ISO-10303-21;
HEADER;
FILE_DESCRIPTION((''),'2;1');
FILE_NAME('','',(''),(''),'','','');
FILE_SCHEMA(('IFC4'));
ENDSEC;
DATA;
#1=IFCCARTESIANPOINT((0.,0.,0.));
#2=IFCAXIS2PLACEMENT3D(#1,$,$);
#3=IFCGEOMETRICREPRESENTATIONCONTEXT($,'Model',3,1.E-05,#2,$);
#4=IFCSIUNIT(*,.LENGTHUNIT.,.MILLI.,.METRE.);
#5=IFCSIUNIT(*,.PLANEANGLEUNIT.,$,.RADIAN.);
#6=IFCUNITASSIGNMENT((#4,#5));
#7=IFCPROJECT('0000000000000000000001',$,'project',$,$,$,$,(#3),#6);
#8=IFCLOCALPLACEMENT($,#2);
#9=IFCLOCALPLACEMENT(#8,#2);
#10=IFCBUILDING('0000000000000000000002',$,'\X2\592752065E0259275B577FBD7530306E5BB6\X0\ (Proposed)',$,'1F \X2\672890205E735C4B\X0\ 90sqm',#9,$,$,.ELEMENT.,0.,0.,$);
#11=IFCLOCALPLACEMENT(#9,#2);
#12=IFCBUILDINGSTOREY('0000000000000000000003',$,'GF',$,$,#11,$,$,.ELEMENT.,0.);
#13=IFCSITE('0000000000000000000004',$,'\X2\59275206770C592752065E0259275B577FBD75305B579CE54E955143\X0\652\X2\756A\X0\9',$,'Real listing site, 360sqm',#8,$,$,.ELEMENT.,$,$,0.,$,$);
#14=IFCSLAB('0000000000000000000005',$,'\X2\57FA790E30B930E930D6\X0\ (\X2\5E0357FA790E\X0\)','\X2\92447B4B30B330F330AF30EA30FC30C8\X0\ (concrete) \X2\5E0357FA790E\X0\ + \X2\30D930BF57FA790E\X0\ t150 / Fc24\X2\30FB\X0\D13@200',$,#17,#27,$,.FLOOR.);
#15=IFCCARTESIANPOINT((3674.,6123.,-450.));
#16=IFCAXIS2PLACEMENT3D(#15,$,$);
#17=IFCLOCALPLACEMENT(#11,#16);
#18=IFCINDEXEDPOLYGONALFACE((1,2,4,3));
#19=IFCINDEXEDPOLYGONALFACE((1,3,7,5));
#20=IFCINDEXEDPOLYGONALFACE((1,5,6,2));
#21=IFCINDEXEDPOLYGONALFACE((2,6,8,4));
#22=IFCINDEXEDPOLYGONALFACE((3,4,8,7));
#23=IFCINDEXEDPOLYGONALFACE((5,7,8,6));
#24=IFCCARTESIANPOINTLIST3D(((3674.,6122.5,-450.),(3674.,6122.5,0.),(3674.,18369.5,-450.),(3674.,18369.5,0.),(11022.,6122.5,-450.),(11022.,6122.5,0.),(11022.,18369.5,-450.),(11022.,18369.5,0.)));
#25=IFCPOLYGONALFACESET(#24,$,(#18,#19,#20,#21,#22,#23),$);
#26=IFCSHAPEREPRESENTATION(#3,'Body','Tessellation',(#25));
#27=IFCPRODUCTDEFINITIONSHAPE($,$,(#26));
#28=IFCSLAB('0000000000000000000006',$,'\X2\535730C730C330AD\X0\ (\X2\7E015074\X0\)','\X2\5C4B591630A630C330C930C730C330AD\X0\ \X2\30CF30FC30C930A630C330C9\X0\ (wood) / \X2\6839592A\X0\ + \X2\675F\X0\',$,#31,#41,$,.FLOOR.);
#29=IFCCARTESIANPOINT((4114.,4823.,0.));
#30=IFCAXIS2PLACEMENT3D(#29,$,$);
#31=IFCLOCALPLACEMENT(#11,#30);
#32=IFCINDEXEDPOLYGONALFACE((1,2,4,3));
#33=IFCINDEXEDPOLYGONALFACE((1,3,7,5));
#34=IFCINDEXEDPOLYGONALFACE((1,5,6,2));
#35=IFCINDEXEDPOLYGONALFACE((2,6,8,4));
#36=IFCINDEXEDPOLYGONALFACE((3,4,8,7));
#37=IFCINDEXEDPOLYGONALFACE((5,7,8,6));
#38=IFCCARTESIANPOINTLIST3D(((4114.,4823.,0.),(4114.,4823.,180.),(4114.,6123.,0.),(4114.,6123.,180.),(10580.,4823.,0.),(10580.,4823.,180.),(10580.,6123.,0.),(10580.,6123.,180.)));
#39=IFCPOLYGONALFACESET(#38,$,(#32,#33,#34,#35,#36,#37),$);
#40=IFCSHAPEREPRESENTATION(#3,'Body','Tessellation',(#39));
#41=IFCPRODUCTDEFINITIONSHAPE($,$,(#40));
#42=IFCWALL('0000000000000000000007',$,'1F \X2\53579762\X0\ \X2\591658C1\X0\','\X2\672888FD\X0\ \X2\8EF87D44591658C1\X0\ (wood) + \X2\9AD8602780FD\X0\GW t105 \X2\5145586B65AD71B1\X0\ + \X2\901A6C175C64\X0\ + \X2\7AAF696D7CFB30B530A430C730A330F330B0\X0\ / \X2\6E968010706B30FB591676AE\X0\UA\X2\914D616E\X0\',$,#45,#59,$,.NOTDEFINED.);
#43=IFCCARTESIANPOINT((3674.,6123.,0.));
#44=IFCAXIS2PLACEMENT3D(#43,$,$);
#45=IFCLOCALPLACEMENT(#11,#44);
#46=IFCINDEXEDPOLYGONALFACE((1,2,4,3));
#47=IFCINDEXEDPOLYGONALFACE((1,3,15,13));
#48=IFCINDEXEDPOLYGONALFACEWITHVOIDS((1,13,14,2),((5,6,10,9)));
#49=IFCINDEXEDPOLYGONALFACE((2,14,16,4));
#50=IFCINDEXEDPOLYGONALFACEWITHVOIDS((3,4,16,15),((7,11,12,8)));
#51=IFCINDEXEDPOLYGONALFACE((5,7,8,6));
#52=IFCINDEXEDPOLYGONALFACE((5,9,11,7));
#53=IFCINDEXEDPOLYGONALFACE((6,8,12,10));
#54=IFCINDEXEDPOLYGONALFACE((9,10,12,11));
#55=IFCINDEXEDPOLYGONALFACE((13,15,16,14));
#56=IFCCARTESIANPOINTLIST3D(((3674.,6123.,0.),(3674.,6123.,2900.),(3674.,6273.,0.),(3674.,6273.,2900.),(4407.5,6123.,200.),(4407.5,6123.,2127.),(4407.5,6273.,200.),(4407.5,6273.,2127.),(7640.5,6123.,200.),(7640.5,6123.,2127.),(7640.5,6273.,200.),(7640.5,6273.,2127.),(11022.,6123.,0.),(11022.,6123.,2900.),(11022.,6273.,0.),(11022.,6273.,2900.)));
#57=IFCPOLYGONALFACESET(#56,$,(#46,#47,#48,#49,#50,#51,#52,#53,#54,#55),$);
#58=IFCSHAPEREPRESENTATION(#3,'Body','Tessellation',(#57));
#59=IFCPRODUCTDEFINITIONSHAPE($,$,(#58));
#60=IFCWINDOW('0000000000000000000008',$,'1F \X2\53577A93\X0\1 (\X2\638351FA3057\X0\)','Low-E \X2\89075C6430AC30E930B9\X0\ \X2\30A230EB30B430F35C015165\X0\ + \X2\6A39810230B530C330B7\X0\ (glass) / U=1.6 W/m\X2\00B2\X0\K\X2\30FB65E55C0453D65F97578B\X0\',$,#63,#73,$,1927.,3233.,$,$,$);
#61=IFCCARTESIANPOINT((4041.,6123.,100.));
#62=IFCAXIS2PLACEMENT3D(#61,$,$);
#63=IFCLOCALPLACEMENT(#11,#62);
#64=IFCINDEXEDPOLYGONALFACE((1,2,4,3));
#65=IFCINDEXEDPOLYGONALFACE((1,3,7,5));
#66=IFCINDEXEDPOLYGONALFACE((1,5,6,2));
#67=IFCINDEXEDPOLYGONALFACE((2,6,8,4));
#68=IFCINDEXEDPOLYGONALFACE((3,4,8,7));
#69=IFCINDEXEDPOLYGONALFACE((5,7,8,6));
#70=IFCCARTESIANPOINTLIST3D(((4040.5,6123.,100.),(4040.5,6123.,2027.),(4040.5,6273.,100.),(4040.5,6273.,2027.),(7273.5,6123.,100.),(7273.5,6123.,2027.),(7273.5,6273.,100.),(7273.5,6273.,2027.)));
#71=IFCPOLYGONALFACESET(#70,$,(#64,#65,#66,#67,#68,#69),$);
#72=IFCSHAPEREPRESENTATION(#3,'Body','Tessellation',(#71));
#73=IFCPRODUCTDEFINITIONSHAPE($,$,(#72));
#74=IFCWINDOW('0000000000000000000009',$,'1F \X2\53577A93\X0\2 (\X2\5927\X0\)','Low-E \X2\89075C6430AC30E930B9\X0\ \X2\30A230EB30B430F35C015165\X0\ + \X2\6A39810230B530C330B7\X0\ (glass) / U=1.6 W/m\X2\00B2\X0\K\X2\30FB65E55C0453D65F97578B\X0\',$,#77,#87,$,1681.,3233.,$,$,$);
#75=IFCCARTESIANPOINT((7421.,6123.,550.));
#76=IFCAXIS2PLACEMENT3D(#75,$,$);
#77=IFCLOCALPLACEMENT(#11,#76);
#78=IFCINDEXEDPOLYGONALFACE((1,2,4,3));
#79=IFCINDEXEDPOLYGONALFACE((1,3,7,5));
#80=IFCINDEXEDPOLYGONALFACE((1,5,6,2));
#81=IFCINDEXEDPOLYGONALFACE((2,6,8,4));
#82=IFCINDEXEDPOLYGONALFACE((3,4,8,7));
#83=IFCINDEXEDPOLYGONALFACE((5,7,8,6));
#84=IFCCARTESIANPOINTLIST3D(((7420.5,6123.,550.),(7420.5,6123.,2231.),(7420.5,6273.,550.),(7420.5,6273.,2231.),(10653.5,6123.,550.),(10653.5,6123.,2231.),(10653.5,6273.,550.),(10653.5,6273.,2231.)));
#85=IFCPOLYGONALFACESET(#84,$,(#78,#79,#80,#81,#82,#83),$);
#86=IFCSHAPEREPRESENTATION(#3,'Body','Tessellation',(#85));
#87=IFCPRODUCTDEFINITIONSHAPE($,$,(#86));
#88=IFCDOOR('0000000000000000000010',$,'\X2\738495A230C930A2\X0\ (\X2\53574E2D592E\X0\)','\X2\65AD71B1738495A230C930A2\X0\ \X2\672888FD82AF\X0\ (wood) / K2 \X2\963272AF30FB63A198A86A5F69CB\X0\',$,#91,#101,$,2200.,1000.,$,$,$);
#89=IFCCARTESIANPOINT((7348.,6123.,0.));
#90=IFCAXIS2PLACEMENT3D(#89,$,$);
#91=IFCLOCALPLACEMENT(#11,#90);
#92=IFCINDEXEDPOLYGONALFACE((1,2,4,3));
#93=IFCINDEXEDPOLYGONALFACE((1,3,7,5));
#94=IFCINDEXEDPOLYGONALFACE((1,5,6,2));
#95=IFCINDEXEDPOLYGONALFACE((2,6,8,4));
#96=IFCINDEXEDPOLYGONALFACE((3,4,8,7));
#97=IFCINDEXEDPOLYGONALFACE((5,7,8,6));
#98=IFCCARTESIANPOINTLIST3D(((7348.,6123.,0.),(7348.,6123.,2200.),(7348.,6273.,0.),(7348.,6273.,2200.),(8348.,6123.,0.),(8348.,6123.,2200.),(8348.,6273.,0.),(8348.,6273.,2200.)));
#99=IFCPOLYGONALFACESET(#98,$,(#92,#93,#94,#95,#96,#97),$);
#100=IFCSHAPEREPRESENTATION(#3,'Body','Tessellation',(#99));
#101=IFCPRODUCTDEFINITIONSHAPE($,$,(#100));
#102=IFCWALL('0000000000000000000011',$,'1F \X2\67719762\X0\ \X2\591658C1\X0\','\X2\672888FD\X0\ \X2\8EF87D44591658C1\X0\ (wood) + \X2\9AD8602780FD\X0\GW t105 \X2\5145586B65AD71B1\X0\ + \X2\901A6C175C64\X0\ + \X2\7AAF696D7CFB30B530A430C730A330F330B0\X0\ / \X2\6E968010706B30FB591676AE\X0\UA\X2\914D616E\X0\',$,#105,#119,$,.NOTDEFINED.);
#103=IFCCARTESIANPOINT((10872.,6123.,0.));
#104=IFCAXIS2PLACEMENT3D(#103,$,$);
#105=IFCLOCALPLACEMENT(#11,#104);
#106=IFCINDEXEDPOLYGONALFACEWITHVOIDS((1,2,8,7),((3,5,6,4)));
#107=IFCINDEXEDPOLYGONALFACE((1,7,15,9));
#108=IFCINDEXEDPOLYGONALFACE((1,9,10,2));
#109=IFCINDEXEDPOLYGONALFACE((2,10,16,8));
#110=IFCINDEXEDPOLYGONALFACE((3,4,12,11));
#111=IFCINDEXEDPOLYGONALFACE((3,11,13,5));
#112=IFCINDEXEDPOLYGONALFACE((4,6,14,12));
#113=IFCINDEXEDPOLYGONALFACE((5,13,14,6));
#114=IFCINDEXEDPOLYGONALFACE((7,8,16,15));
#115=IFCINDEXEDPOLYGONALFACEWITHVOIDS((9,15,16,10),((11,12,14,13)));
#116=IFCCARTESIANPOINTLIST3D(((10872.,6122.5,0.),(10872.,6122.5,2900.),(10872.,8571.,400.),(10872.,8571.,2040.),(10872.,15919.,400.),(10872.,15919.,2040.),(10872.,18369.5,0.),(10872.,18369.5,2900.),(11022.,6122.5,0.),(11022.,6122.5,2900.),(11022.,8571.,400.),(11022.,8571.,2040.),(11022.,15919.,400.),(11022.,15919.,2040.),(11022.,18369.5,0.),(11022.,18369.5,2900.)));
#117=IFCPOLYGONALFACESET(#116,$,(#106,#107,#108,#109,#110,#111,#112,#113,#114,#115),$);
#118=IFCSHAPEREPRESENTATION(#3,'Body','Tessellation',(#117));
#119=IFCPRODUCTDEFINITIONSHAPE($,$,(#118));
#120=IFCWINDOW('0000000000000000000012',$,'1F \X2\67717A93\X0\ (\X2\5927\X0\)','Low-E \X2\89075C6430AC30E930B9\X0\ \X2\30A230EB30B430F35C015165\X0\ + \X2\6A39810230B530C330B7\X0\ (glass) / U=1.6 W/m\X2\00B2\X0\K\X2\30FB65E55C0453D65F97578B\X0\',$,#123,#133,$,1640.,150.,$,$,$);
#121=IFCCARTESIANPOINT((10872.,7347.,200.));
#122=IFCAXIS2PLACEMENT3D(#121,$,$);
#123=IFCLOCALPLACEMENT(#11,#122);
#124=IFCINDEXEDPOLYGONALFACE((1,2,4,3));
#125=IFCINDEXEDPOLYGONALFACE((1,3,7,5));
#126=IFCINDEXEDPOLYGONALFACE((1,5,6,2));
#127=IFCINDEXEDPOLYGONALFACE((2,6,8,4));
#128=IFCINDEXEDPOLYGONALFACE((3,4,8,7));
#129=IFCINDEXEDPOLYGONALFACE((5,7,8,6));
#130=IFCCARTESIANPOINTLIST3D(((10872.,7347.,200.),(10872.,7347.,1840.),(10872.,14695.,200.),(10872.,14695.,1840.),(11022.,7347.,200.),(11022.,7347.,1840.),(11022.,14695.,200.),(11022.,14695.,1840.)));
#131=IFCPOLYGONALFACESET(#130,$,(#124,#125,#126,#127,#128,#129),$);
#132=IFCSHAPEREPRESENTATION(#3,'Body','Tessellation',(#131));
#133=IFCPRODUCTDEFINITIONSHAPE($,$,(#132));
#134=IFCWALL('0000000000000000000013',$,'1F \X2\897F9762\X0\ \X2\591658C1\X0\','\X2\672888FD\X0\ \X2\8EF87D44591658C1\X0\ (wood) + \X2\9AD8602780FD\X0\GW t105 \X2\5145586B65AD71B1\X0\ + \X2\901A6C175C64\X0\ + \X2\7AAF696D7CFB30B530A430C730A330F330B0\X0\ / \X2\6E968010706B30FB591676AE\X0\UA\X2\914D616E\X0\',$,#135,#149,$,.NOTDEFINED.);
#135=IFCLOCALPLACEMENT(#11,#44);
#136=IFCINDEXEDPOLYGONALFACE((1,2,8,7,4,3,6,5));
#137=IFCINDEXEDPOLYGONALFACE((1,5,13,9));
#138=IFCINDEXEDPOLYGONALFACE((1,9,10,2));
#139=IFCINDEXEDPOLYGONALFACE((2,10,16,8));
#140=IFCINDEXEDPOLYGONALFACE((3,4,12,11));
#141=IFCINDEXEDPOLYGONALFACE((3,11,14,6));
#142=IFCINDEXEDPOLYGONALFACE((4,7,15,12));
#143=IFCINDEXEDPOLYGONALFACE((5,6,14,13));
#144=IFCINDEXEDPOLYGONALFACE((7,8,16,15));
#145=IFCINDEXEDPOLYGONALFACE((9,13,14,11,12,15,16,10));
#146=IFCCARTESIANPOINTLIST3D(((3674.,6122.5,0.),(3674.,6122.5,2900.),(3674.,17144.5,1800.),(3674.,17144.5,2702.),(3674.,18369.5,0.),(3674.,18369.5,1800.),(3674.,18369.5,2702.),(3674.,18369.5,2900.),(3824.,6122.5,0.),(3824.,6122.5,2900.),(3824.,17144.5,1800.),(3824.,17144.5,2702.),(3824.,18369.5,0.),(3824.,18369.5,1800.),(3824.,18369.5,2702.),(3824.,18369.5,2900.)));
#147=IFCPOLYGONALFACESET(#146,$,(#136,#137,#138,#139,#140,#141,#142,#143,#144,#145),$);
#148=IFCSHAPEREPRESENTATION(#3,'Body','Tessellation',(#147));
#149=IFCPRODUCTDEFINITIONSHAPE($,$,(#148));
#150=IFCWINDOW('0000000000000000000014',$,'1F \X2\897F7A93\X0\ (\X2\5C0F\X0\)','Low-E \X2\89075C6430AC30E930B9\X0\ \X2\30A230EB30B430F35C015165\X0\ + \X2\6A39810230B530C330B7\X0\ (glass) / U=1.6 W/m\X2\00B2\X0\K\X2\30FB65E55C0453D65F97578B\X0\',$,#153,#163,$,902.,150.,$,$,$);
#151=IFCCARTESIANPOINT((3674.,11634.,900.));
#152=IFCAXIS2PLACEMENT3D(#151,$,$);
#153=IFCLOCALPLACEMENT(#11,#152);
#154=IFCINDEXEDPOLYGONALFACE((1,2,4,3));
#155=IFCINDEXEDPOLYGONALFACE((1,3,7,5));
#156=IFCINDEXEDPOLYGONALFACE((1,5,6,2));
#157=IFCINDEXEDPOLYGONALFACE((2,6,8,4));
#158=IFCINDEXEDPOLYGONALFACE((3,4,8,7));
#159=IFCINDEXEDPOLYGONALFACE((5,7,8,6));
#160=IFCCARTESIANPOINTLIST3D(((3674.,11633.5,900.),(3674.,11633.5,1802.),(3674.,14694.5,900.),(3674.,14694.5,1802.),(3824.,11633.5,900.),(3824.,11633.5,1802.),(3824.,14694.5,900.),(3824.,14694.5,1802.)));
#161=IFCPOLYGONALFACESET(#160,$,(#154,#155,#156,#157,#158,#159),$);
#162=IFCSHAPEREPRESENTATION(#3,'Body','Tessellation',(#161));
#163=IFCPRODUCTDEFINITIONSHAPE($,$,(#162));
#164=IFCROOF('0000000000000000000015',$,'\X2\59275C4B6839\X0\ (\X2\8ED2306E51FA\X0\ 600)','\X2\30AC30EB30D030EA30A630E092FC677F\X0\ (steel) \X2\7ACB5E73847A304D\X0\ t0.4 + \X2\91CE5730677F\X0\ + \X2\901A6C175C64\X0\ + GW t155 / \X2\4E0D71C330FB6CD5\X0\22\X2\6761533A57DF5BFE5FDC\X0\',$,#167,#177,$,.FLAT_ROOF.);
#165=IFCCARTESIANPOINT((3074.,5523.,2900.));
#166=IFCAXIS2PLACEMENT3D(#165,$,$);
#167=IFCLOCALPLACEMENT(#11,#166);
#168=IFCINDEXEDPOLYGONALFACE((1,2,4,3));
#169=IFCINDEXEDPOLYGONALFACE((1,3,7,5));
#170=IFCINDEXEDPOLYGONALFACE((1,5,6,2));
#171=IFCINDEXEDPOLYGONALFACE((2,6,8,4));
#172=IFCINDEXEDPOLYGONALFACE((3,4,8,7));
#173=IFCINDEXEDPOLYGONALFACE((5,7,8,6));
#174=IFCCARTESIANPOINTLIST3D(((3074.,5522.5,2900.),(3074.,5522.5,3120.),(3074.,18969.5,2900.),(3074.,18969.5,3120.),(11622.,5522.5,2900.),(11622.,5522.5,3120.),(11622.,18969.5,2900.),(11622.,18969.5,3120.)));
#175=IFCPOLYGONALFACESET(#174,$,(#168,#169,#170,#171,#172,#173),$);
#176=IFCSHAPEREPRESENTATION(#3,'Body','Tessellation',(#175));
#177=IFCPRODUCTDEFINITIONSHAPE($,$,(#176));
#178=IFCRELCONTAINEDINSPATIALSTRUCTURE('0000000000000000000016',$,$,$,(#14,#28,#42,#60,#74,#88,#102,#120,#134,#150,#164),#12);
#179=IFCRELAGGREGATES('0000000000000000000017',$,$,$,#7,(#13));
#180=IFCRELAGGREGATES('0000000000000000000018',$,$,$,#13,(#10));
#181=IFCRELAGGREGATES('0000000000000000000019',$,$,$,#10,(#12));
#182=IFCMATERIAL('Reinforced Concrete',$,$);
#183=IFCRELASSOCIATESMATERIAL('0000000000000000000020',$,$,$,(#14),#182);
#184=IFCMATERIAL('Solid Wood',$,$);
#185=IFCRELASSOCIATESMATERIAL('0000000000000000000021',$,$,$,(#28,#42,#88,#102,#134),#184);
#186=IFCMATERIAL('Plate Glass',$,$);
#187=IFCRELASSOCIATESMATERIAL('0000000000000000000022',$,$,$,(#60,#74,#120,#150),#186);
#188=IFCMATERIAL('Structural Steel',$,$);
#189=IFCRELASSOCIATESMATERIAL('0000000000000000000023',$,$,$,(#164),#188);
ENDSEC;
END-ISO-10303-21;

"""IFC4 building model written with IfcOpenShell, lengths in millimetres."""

from ifc_helpers import new_model, si_unit, frame, frame_2d, origin, place, context, project, spatial, rectangle, extrude, material, element, fill, save


model = new_model("IFC4")

# Units and contexts
model_context = context("Model", 3, precision=1e-05, world=origin())
ifc_project = project(units=[si_unit("LENGTHUNIT", "METRE", prefix="MILLI"), si_unit("PLANEANGLEUNIT", "RADIAN")], contexts=[model_context])

# Site, building, storey
site_placement = place(None, origin())
site = spatial("IfcSite", under=ifc_project, at=site_placement, Name="大分県大分市大字羽田字鳥井元652番9", ObjectType="Real listing site, 360sqm", CompositionType="ELEMENT", RefElevation=0.0)
building_placement = place(site_placement, origin())
building = spatial("IfcBuilding", under=site, at=building_placement, Name="大分市大字羽田の家 (Proposed)", ObjectType="1F 木造平屋 90sqm", CompositionType="ELEMENT", ElevationOfRefHeight=0.0, ElevationOfTerrain=0.0)
storey_placement = place(building_placement, origin())
storey = spatial("IfcBuildingStorey", under=building, at=storey_placement, Name="GF", CompositionType="ELEMENT", Elevation=0.0)

# Slabs
ifc_material_1 = material(Name="Reinforced Concrete")
slab_1_placement = place(storey_placement, frame((3674.0, 6123.0, -450.0)))
element("IfcSlab", 1, at=slab_1_placement, inside=storey, material=ifc_material_1, Name="基礎スラブ (布基礎)", Description="鉄筋コンクリート (concrete) 布基礎 + ベタ基礎 t150 / Fc24・D13@200", PredefinedType="FLOOR", context=model_context, shape_type="SweptSolid", body=[
    extrude(rectangle(XDim=7348.0, YDim=12247.0, at=frame_2d((3674.0, 6123.0))), frame((3674.0, 6123.0, -450.0)), (0.0, 0.0, 1.0), 450.0),
])
ifc_material_2 = material(Name="Solid Wood")
slab_2_placement = place(storey_placement, frame((4114.0, 4823.0, 0.0)))
element("IfcSlab", 2, at=slab_2_placement, inside=storey, material=ifc_material_2, Name="南デッキ (縁側)", Description="屋外ウッドデッキ ハードウッド (wood) / 根太 + 束", PredefinedType="FLOOR", context=model_context, shape_type="SweptSolid", body=[
    extrude(rectangle(XDim=6466.0, YDim=1300.0, at=frame_2d((3233.0, 650.0))), frame((4114.0, 4823.0, 0.0)), (0.0, 0.0, 1.0), 180.0),
])

# Wall, openings, windows, door
wall_1_placement = place(storey_placement, frame((3674.0, 6123.0, 0.0)))
wall_1 = element("IfcWall", 3, at=wall_1_placement, inside=storey, material=ifc_material_2, Name="1F 南面 外壁", Description="木製 軸組外壁 (wood) + 高性能GW t105 充填断熱 + 通気層 + 窯業系サイディング / 準耐火・外皮UA配慮", PredefinedType="NOTDEFINED", context=model_context, shape_type="SweptSolid", body=[
    extrude(rectangle(XDim=7348.0, YDim=150.0, at=frame_2d((3674.0, 75.0))), frame((3674.0, 6123.0, 0.0)), (0.0, 0.0, 1.0), 2900.0),
])
opening_1_placement = place(storey_placement, frame((4041.0, 6123.0, 100.0)))
opening_1 = element("IfcOpeningElement", 4, at=opening_1_placement, cuts=wall_1, PredefinedType="NOTDEFINED", context=model_context, shape_type="SweptSolid", body=[
    extrude(rectangle(XDim=3233.0, YDim=150.0, at=frame_2d((1616.0, 75.0))), frame((4041.0, 6123.0, 100.0)), (0.0, 0.0, 1.0), 1927.0),
])
opening_2_placement = place(storey_placement, frame((7421.0, 6123.0, 550.0)))
opening_2 = element("IfcOpeningElement", 5, at=opening_2_placement, cuts=wall_1, PredefinedType="NOTDEFINED", context=model_context, shape_type="SweptSolid", body=[
    extrude(rectangle(XDim=3233.0, YDim=150.0, at=frame_2d((1616.0, 75.0))), frame((7421.0, 6123.0, 550.0)), (0.0, 0.0, 1.0), 1681.0),
])
opening_3_placement = place(storey_placement, frame((7348.0, 6123.0, 0.0)))
opening_3 = element("IfcOpeningElement", 6, at=opening_3_placement, cuts=wall_1, PredefinedType="NOTDEFINED", context=model_context, shape_type="SweptSolid", body=[
    extrude(rectangle(XDim=1000.0, YDim=150.0, at=frame_2d((500.0, 75.0))), frame((7348.0, 6123.0, 0.0)), (0.0, 0.0, 1.0), 2200.0),
])
ifc_material_3 = material(Name="Plate Glass")
window_1_placement = place(storey_placement, frame((4041.0, 6123.0, 100.0)))
window_1 = element("IfcWindow", 7, at=window_1_placement, inside=storey, material=ifc_material_3, Name="1F 南窓1 (掃出し)", Description="Low-E 複層ガラス アルゴン封入 + 樹脂サッシ (glass) / U=1.6 W/m²K・日射取得型", OverallHeight=1927.0, OverallWidth=3233.0, context=model_context, shape_type="SweptSolid", body=[
    extrude(rectangle(XDim=3233.0, YDim=150.0, at=frame_2d((1616.0, 75.0))), frame((4041.0, 6123.0, 100.0)), (0.0, 0.0, 1.0), 1927.0),
])
fill(opening_1, window_1)
window_2_placement = place(storey_placement, frame((7421.0, 6123.0, 550.0)))
window_2 = element("IfcWindow", 8, at=window_2_placement, inside=storey, material=ifc_material_3, Name="1F 南窓2 (大)", Description="Low-E 複層ガラス アルゴン封入 + 樹脂サッシ (glass) / U=1.6 W/m²K・日射取得型", OverallHeight=1681.0, OverallWidth=3233.0, context=model_context, shape_type="SweptSolid", body=[
    extrude(rectangle(XDim=3233.0, YDim=150.0, at=frame_2d((1616.0, 75.0))), frame((7421.0, 6123.0, 550.0)), (0.0, 0.0, 1.0), 1681.0),
])
fill(opening_2, window_2)
door_placement = place(storey_placement, frame((7348.0, 6123.0, 0.0)))
door = element("IfcDoor", 9, at=door_placement, inside=storey, material=ifc_material_2, Name="玄関ドア (南中央)", Description="断熱玄関ドア 木製芯 (wood) / K2 防犯・採風機構", OverallHeight=2200.0, OverallWidth=1000.0, context=model_context, shape_type="SweptSolid", body=[
    extrude(rectangle(XDim=1000.0, YDim=150.0, at=frame_2d((500.0, 75.0))), frame((7348.0, 6123.0, 0.0)), (0.0, 0.0, 1.0), 2200.0),
])
fill(opening_3, door)

# Walls, openings, windows
wall_2_placement = place(storey_placement, frame((10872.0, 6123.0, 0.0)))
wall_2 = element("IfcWall", 10, at=wall_2_placement, inside=storey, material=ifc_material_2, Name="1F 東面 外壁", Description="木製 軸組外壁 (wood) + 高性能GW t105 充填断熱 + 通気層 + 窯業系サイディング / 準耐火・外皮UA配慮", PredefinedType="NOTDEFINED", context=model_context, shape_type="SweptSolid", body=[
    extrude(rectangle(XDim=150.0, YDim=12247.0, at=frame_2d((75.0, 6123.0))), frame((10872.0, 6123.0, 0.0)), (0.0, 0.0, 1.0), 2900.0),
])
opening_4_placement = place(storey_placement, frame((10872.0, 7347.0, 200.0)))
opening_4 = element("IfcOpeningElement", 11, at=opening_4_placement, cuts=wall_2, PredefinedType="NOTDEFINED", context=model_context, shape_type="SweptSolid", body=[
    extrude(rectangle(XDim=150.0, YDim=7348.0, at=frame_2d((75.0, 3674.0))), frame((10872.0, 7347.0, 200.0)), (0.0, 0.0, 1.0), 1640.0),
])
window_3_placement = place(storey_placement, frame((10872.0, 7347.0, 200.0)))
window_3 = element("IfcWindow", 12, at=window_3_placement, inside=storey, material=ifc_material_3, Name="1F 東窓 (大)", Description="Low-E 複層ガラス アルゴン封入 + 樹脂サッシ (glass) / U=1.6 W/m²K・日射取得型", OverallHeight=1640.0, OverallWidth=150.0, context=model_context, shape_type="SweptSolid", body=[
    extrude(rectangle(XDim=150.0, YDim=7348.0, at=frame_2d((75.0, 3674.0))), frame((10872.0, 7347.0, 200.0)), (0.0, 0.0, 1.0), 1640.0),
])
fill(opening_4, window_3)
wall_3_placement = place(storey_placement, frame((3674.0, 6123.0, 0.0)))
wall_3 = element("IfcWall", 13, at=wall_3_placement, inside=storey, material=ifc_material_2, Name="1F 西面 外壁", Description="木製 軸組外壁 (wood) + 高性能GW t105 充填断熱 + 通気層 + 窯業系サイディング / 準耐火・外皮UA配慮", PredefinedType="NOTDEFINED", context=model_context, shape_type="SweptSolid", body=[
    extrude(rectangle(XDim=150.0, YDim=12247.0, at=frame_2d((75.0, 6123.0))), frame((3674.0, 6123.0, 0.0)), (0.0, 0.0, 1.0), 2900.0),
])
opening_5_placement = place(storey_placement, frame((3674.0, 11634.0, 900.0)))
opening_5 = element("IfcOpeningElement", 14, at=opening_5_placement, cuts=wall_3, PredefinedType="NOTDEFINED", context=model_context, shape_type="SweptSolid", body=[
    extrude(rectangle(XDim=150.0, YDim=3061.0, at=frame_2d((75.0, 1530.0))), frame((3674.0, 11634.0, 900.0)), (0.0, 0.0, 1.0), 902.0),
])
window_4_placement = place(storey_placement, frame((3674.0, 11634.0, 900.0)))
window_4 = element("IfcWindow", 15, at=window_4_placement, inside=storey, material=ifc_material_3, Name="1F 西窓 (小)", Description="Low-E 複層ガラス アルゴン封入 + 樹脂サッシ (glass) / U=1.6 W/m²K・日射取得型", OverallHeight=902.0, OverallWidth=150.0, context=model_context, shape_type="SweptSolid", body=[
    extrude(rectangle(XDim=150.0, YDim=3061.0, at=frame_2d((75.0, 1530.0))), frame((3674.0, 11634.0, 900.0)), (0.0, 0.0, 1.0), 902.0),
])
fill(opening_5, window_4)

# Roof
ifc_material_4 = material(Name="Structural Steel")
roof_placement = place(storey_placement, frame((3074.0, 5523.0, 2900.0)))
element("IfcRoof", 16, at=roof_placement, inside=storey, material=ifc_material_4, Name="大屋根 (軒の出 600)", Description="ガルバリウム鋼板 (steel) 立平葺き t0.4 + 野地板 + 通気層 + GW t155 / 不燃・法22条区域対応", PredefinedType="FLAT_ROOF", context=model_context, shape_type="SweptSolid", body=[
    extrude(rectangle(XDim=8548.0, YDim=13447.0, at=frame_2d((4274.0, 6723.0))), frame((3074.0, 5523.0, 2900.0)), (0.0, 0.0, 1.0), 220.0),
])

save(model, "model.ifc")
